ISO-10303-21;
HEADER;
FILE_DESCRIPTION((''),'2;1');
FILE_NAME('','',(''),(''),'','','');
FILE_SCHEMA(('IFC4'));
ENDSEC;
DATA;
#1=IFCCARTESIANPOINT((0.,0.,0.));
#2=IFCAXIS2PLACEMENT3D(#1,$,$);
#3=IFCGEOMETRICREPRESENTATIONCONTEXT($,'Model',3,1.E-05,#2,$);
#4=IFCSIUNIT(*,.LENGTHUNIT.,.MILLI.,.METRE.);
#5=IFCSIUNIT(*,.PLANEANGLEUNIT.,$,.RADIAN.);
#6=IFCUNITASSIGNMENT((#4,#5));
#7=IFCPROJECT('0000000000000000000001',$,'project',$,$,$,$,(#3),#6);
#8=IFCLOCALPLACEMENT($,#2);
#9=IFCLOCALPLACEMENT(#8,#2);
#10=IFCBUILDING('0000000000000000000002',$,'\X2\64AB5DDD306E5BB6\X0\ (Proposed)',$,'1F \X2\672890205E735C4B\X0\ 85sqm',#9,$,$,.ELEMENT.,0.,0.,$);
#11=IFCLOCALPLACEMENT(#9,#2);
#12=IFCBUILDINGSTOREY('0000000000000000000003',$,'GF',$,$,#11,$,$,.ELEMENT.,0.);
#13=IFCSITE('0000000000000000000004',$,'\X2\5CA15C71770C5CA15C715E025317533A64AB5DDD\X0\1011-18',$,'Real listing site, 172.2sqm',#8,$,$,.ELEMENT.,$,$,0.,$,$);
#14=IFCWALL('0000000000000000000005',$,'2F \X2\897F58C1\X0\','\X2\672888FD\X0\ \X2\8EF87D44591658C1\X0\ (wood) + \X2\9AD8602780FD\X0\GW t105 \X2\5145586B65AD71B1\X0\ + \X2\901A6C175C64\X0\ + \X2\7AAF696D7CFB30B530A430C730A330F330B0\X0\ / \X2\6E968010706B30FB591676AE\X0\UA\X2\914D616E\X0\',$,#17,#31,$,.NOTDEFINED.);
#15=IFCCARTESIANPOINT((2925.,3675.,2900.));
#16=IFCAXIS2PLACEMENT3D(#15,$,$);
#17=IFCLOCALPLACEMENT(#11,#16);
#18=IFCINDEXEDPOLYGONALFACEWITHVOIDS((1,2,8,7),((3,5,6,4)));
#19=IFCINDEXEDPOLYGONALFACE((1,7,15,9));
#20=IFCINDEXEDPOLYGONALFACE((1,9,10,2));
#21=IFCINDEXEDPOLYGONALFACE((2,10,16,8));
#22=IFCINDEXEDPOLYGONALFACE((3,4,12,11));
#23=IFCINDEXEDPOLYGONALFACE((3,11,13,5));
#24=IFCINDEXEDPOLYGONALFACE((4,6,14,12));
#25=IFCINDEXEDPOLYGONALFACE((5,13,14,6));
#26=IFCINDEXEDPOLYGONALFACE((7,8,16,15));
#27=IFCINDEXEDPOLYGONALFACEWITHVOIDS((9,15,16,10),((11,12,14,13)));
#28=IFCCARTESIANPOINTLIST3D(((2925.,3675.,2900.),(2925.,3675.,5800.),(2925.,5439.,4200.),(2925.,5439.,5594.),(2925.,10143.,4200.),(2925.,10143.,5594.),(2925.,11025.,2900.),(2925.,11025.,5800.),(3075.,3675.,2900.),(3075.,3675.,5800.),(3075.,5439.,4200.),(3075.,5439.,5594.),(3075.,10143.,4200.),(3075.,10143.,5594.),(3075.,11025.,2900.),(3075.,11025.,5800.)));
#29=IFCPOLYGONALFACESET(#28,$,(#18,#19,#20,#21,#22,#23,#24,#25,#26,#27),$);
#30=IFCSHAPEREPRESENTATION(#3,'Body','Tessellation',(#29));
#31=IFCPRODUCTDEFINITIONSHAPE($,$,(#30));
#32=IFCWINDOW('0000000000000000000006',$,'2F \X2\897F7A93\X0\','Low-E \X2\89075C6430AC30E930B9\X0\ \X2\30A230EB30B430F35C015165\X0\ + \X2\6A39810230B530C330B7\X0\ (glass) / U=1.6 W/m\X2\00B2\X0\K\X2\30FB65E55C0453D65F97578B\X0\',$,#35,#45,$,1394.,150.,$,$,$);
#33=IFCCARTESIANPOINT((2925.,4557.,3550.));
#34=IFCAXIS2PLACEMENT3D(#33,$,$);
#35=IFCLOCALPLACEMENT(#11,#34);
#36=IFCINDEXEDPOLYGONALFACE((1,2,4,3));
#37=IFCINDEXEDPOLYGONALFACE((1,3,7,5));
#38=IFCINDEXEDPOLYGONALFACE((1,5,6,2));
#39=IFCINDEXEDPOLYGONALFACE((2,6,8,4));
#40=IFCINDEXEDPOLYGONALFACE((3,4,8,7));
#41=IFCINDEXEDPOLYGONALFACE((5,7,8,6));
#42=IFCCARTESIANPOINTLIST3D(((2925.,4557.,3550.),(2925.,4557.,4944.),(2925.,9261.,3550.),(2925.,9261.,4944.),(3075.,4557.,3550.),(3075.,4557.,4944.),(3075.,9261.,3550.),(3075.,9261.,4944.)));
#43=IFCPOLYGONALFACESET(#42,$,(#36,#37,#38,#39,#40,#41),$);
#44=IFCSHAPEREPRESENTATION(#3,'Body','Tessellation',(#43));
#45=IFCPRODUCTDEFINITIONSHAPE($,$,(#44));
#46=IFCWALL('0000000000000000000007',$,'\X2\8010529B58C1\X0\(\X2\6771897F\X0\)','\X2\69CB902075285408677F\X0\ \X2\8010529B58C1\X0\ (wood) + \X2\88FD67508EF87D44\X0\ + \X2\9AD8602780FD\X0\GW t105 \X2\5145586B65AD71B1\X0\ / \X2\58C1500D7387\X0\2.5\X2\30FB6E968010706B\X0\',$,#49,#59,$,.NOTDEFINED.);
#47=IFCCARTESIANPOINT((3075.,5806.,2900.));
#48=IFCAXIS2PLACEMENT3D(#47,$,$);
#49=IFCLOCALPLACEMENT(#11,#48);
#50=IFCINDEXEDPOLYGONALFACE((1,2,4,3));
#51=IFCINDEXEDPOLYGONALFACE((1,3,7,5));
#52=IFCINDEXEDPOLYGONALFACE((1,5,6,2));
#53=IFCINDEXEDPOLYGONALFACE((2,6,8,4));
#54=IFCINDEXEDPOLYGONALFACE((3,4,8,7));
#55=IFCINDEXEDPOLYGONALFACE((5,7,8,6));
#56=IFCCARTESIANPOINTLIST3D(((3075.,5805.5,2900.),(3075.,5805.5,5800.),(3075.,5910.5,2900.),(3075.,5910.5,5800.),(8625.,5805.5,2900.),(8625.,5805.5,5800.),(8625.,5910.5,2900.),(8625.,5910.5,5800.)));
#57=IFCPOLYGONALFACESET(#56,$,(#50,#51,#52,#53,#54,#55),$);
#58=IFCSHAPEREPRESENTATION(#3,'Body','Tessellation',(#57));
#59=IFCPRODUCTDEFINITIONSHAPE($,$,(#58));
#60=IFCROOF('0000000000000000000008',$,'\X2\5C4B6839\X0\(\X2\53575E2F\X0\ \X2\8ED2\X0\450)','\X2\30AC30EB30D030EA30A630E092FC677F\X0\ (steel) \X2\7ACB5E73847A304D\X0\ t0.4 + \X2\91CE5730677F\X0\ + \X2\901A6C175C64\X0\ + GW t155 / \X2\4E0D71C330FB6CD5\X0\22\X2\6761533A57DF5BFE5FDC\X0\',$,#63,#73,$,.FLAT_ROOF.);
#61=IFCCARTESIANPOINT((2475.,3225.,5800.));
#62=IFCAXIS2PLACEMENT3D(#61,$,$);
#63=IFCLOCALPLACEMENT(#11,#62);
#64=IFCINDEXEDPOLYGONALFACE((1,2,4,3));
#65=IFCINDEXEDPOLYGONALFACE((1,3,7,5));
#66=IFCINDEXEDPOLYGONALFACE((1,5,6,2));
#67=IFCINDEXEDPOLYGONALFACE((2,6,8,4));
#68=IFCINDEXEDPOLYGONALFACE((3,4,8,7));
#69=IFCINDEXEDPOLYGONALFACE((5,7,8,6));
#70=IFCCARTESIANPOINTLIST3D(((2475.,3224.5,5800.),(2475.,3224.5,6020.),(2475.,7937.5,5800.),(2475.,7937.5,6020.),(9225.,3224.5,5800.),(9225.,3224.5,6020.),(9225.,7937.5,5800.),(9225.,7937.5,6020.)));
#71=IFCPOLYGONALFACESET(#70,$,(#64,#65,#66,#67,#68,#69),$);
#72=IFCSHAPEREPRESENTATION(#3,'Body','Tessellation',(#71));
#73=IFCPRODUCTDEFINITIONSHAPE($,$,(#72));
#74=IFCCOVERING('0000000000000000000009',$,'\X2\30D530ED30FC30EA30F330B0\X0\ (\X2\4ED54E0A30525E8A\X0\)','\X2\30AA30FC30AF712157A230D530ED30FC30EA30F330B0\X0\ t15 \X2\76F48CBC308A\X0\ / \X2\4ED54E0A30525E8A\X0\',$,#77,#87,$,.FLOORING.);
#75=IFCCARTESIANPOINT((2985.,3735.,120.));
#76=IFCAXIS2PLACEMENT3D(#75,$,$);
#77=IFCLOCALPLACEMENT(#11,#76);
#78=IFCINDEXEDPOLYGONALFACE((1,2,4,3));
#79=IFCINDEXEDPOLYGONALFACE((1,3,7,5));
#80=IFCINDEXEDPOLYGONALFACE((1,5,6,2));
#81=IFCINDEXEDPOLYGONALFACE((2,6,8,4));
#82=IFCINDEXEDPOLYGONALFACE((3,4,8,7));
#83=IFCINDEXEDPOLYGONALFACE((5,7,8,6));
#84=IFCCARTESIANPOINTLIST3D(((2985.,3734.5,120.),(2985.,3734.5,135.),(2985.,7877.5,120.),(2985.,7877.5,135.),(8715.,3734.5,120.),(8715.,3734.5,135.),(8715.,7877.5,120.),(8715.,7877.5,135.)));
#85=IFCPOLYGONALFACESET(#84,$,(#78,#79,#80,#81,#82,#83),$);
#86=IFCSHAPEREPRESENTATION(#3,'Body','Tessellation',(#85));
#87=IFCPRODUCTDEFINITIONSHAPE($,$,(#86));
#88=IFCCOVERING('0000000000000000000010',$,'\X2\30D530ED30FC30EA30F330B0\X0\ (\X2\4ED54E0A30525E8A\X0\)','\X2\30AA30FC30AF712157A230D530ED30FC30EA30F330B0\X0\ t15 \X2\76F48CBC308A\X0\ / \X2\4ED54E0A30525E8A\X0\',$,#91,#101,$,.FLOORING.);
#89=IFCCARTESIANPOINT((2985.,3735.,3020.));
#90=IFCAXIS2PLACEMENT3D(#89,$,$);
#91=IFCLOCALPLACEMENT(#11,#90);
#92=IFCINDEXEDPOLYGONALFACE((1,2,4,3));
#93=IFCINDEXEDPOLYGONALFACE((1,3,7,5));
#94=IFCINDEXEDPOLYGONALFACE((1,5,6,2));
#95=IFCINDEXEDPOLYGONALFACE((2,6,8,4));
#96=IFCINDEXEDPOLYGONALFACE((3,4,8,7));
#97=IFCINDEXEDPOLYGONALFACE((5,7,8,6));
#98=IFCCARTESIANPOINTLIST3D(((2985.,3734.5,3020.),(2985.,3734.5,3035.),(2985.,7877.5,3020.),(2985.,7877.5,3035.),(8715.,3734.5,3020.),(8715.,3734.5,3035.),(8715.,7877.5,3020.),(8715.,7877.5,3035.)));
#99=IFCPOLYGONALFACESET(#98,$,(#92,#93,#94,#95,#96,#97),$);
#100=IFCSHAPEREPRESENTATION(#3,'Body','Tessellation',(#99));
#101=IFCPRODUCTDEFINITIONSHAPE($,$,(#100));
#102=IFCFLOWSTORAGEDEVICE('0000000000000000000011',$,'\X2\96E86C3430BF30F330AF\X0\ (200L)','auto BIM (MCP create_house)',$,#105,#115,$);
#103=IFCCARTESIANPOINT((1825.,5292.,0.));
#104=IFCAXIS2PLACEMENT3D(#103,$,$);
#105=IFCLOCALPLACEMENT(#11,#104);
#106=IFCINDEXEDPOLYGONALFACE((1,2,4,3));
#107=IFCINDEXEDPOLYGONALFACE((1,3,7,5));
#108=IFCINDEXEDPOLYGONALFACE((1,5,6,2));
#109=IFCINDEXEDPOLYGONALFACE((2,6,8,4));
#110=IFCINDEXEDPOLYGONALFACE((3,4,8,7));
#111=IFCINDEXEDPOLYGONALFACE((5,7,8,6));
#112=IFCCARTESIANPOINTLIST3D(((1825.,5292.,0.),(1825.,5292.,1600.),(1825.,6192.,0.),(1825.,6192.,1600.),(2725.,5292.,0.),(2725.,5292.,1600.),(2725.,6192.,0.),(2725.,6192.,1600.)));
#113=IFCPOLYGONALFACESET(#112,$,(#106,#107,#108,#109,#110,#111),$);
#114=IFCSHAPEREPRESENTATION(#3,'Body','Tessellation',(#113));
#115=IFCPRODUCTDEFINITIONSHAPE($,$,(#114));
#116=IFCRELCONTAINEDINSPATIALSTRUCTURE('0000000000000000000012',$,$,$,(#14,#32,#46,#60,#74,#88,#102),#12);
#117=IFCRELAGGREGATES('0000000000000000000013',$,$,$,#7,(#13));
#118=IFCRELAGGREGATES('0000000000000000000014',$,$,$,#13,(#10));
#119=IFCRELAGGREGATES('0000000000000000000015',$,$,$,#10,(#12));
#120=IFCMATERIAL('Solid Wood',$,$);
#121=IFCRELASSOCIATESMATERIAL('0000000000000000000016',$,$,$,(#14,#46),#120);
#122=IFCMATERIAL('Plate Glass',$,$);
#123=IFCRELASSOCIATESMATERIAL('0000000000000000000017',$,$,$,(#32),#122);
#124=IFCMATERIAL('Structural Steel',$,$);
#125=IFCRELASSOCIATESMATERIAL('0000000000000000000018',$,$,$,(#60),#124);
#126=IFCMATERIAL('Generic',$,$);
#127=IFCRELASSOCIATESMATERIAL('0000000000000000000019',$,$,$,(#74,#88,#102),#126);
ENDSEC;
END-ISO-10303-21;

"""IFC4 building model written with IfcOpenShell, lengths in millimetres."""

from ifc_helpers import new_model, si_unit, frame, frame_2d, origin, place, context, project, spatial, rectangle, extrude, material, element, fill, save


model = new_model("IFC4")

# Units and contexts
model_context = context("Model", 3, precision=1e-05, world=origin())
ifc_project = project(units=[si_unit("LENGTHUNIT", "METRE", prefix="MILLI"), si_unit("PLANEANGLEUNIT", "RADIAN")], contexts=[model_context])

# Site, building, storey
site_placement = place(None, origin())
site = spatial("IfcSite", under=ifc_project, at=site_placement, Name="岡山県岡山市北区撫川1011-18", ObjectType="Real listing site, 172.2sqm", CompositionType="ELEMENT", RefElevation=0.0)
building_placement = place(site_placement, origin())
building = spatial("IfcBuilding", under=site, at=building_placement, Name="撫川の家 (Proposed)", ObjectType="1F 木造平屋 85sqm", CompositionType="ELEMENT", ElevationOfRefHeight=0.0, ElevationOfTerrain=0.0)
storey_placement = place(building_placement, origin())
storey = spatial("IfcBuildingStorey", under=building, at=storey_placement, Name="GF", CompositionType="ELEMENT", Elevation=0.0)

# Shared definitions
ifc_material_1 = material(Name="Solid Wood")
ifc_material_2 = material(Name="Generic")

# Shared definitions
ifc_material_3 = material(Name="Plate Glass")

# Wall, opening, window
wall_1_placement = place(storey_placement, frame((2925.0, 3675.0, 2900.0)))
wall_1 = element("IfcWall", 1, at=wall_1_placement, inside=storey, material=ifc_material_1, Name="2F 西壁", Description="木製 軸組外壁 (wood) + 高性能GW t105 充填断熱 + 通気層 + 窯業系サイディング / 準耐火・外皮UA配慮", PredefinedType="NOTDEFINED", context=model_context, shape_type="SweptSolid", body=[
    extrude(rectangle(XDim=150.0, YDim=7350.0, at=frame_2d((75.0, 3675.0))), frame((2925.0, 3675.0, 2900.0)), (0.0, 0.0, 1.0), 2900.0),
])
opening_1_placement = place(storey_placement, frame((2925.0, 4557.0, 3550.0)))
opening_1 = element("IfcOpeningElement", 2, at=opening_1_placement, cuts=wall_1, PredefinedType="NOTDEFINED", context=model_context, shape_type="SweptSolid", body=[
    extrude(rectangle(XDim=150.0, YDim=4704.0, at=frame_2d((75.0, 2352.0))), frame((2925.0, 4557.0, 3550.0)), (0.0, 0.0, 1.0), 1394.0),
])
window_1_placement = place(storey_placement, frame((2925.0, 4557.0, 3550.0)))
window_1 = element("IfcWindow", 3, at=window_1_placement, inside=storey, material=ifc_material_3, Name="2F 西窓", Description="Low-E 複層ガラス アルゴン封入 + 樹脂サッシ (glass) / U=1.6 W/m²K・日射取得型", OverallHeight=1394.0, OverallWidth=150.0, context=model_context, shape_type="SweptSolid", body=[
    extrude(rectangle(XDim=150.0, YDim=4704.0, at=frame_2d((75.0, 2352.0))), frame((2925.0, 4557.0, 3550.0)), (0.0, 0.0, 1.0), 1394.0),
])
fill(opening_1, window_1)

# Wall
wall_2_placement = place(storey_placement, frame((3075.0, 5806.0, 2900.0)))
element("IfcWall", 4, at=wall_2_placement, inside=storey, material=ifc_material_1, Name="耐力壁(東西)", Description="構造用合板 耐力壁 (wood) + 製材軸組 + 高性能GW t105 充填断熱 / 壁倍率2.5・準耐火", PredefinedType="NOTDEFINED", context=model_context, shape_type="SweptSolid", body=[
    extrude(rectangle(XDim=5550.0, YDim=105.0, at=frame_2d((2775.0, 52.0))), frame((3075.0, 5806.0, 2900.0)), (0.0, 0.0, 1.0), 2900.0),
])

# Roof
ifc_material_4 = material(Name="Structural Steel")
for number, where, name in (
    (5, (2475.0, 3225.0, 5800.0), "屋根(南帯 軒450)"),
):
    element("IfcRoof", number, at=place(storey_placement, frame(where)), inside=storey, material=ifc_material_4, Name=name, Description="ガルバリウム鋼板 (steel) 立平葺き t0.4 + 野地板 + 通気層 + GW t155 / 不燃・法22条区域対応", PredefinedType="FLAT_ROOF", context=model_context, shape_type="SweptSolid", body=[
        extrude(rectangle(XDim=6750.0, YDim=4713.0, at=frame_2d((3375.0, 2356.0))), frame((2475.0, 3225.0, 5800.0)), (0.0, 0.0, 1.0), 220.0),
    ])

# Coverings
covering_1_placement = place(storey_placement, frame((2985.0, 3735.0, 120.0)))
element("IfcCovering", 6, at=covering_1_placement, inside=storey, material=ifc_material_2, Name="フローリング (仕上げ床)", Description="オーク無垢フローリング t15 直貼り / 仕上げ床", PredefinedType="FLOORING", context=model_context, shape_type="SweptSolid", body=[
    extrude(rectangle(XDim=5730.0, YDim=4143.0, at=frame_2d((2865.0, 2071.0))), frame((2985.0, 3735.0, 120.0)), (0.0, 0.0, 1.0), 15.0),
])
covering_2_placement = place(storey_placement, frame((2985.0, 3735.0, 3020.0)))
element("IfcCovering", 7, at=covering_2_placement, inside=storey, material=ifc_material_2, Name="フローリング (仕上げ床)", Description="オーク無垢フローリング t15 直貼り / 仕上げ床", PredefinedType="FLOORING", context=model_context, shape_type="SweptSolid", body=[
    extrude(rectangle(XDim=5730.0, YDim=4143.0, at=frame_2d((2865.0, 2071.0))), frame((2985.0, 3735.0, 3020.0)), (0.0, 0.0, 1.0), 15.0),
])

# Flow storage device
flow_storage_device_placement = place(storey_placement, frame((1825.0, 5292.0, 0.0)))
element("IfcFlowStorageDevice", 8, at=flow_storage_device_placement, inside=storey, material=ifc_material_2, Name="雨水タンク (200L)", Description="auto BIM (MCP create_house)", context=model_context, shape_type="SweptSolid", body=[
    extrude(rectangle(XDim=900.0, YDim=900.0, at=frame_2d((450.0, 450.0))), frame((1825.0, 5292.0, 0.0)), (0.0, 0.0, 1.0), 1600.0),
])

save(model, "model.ifc")
